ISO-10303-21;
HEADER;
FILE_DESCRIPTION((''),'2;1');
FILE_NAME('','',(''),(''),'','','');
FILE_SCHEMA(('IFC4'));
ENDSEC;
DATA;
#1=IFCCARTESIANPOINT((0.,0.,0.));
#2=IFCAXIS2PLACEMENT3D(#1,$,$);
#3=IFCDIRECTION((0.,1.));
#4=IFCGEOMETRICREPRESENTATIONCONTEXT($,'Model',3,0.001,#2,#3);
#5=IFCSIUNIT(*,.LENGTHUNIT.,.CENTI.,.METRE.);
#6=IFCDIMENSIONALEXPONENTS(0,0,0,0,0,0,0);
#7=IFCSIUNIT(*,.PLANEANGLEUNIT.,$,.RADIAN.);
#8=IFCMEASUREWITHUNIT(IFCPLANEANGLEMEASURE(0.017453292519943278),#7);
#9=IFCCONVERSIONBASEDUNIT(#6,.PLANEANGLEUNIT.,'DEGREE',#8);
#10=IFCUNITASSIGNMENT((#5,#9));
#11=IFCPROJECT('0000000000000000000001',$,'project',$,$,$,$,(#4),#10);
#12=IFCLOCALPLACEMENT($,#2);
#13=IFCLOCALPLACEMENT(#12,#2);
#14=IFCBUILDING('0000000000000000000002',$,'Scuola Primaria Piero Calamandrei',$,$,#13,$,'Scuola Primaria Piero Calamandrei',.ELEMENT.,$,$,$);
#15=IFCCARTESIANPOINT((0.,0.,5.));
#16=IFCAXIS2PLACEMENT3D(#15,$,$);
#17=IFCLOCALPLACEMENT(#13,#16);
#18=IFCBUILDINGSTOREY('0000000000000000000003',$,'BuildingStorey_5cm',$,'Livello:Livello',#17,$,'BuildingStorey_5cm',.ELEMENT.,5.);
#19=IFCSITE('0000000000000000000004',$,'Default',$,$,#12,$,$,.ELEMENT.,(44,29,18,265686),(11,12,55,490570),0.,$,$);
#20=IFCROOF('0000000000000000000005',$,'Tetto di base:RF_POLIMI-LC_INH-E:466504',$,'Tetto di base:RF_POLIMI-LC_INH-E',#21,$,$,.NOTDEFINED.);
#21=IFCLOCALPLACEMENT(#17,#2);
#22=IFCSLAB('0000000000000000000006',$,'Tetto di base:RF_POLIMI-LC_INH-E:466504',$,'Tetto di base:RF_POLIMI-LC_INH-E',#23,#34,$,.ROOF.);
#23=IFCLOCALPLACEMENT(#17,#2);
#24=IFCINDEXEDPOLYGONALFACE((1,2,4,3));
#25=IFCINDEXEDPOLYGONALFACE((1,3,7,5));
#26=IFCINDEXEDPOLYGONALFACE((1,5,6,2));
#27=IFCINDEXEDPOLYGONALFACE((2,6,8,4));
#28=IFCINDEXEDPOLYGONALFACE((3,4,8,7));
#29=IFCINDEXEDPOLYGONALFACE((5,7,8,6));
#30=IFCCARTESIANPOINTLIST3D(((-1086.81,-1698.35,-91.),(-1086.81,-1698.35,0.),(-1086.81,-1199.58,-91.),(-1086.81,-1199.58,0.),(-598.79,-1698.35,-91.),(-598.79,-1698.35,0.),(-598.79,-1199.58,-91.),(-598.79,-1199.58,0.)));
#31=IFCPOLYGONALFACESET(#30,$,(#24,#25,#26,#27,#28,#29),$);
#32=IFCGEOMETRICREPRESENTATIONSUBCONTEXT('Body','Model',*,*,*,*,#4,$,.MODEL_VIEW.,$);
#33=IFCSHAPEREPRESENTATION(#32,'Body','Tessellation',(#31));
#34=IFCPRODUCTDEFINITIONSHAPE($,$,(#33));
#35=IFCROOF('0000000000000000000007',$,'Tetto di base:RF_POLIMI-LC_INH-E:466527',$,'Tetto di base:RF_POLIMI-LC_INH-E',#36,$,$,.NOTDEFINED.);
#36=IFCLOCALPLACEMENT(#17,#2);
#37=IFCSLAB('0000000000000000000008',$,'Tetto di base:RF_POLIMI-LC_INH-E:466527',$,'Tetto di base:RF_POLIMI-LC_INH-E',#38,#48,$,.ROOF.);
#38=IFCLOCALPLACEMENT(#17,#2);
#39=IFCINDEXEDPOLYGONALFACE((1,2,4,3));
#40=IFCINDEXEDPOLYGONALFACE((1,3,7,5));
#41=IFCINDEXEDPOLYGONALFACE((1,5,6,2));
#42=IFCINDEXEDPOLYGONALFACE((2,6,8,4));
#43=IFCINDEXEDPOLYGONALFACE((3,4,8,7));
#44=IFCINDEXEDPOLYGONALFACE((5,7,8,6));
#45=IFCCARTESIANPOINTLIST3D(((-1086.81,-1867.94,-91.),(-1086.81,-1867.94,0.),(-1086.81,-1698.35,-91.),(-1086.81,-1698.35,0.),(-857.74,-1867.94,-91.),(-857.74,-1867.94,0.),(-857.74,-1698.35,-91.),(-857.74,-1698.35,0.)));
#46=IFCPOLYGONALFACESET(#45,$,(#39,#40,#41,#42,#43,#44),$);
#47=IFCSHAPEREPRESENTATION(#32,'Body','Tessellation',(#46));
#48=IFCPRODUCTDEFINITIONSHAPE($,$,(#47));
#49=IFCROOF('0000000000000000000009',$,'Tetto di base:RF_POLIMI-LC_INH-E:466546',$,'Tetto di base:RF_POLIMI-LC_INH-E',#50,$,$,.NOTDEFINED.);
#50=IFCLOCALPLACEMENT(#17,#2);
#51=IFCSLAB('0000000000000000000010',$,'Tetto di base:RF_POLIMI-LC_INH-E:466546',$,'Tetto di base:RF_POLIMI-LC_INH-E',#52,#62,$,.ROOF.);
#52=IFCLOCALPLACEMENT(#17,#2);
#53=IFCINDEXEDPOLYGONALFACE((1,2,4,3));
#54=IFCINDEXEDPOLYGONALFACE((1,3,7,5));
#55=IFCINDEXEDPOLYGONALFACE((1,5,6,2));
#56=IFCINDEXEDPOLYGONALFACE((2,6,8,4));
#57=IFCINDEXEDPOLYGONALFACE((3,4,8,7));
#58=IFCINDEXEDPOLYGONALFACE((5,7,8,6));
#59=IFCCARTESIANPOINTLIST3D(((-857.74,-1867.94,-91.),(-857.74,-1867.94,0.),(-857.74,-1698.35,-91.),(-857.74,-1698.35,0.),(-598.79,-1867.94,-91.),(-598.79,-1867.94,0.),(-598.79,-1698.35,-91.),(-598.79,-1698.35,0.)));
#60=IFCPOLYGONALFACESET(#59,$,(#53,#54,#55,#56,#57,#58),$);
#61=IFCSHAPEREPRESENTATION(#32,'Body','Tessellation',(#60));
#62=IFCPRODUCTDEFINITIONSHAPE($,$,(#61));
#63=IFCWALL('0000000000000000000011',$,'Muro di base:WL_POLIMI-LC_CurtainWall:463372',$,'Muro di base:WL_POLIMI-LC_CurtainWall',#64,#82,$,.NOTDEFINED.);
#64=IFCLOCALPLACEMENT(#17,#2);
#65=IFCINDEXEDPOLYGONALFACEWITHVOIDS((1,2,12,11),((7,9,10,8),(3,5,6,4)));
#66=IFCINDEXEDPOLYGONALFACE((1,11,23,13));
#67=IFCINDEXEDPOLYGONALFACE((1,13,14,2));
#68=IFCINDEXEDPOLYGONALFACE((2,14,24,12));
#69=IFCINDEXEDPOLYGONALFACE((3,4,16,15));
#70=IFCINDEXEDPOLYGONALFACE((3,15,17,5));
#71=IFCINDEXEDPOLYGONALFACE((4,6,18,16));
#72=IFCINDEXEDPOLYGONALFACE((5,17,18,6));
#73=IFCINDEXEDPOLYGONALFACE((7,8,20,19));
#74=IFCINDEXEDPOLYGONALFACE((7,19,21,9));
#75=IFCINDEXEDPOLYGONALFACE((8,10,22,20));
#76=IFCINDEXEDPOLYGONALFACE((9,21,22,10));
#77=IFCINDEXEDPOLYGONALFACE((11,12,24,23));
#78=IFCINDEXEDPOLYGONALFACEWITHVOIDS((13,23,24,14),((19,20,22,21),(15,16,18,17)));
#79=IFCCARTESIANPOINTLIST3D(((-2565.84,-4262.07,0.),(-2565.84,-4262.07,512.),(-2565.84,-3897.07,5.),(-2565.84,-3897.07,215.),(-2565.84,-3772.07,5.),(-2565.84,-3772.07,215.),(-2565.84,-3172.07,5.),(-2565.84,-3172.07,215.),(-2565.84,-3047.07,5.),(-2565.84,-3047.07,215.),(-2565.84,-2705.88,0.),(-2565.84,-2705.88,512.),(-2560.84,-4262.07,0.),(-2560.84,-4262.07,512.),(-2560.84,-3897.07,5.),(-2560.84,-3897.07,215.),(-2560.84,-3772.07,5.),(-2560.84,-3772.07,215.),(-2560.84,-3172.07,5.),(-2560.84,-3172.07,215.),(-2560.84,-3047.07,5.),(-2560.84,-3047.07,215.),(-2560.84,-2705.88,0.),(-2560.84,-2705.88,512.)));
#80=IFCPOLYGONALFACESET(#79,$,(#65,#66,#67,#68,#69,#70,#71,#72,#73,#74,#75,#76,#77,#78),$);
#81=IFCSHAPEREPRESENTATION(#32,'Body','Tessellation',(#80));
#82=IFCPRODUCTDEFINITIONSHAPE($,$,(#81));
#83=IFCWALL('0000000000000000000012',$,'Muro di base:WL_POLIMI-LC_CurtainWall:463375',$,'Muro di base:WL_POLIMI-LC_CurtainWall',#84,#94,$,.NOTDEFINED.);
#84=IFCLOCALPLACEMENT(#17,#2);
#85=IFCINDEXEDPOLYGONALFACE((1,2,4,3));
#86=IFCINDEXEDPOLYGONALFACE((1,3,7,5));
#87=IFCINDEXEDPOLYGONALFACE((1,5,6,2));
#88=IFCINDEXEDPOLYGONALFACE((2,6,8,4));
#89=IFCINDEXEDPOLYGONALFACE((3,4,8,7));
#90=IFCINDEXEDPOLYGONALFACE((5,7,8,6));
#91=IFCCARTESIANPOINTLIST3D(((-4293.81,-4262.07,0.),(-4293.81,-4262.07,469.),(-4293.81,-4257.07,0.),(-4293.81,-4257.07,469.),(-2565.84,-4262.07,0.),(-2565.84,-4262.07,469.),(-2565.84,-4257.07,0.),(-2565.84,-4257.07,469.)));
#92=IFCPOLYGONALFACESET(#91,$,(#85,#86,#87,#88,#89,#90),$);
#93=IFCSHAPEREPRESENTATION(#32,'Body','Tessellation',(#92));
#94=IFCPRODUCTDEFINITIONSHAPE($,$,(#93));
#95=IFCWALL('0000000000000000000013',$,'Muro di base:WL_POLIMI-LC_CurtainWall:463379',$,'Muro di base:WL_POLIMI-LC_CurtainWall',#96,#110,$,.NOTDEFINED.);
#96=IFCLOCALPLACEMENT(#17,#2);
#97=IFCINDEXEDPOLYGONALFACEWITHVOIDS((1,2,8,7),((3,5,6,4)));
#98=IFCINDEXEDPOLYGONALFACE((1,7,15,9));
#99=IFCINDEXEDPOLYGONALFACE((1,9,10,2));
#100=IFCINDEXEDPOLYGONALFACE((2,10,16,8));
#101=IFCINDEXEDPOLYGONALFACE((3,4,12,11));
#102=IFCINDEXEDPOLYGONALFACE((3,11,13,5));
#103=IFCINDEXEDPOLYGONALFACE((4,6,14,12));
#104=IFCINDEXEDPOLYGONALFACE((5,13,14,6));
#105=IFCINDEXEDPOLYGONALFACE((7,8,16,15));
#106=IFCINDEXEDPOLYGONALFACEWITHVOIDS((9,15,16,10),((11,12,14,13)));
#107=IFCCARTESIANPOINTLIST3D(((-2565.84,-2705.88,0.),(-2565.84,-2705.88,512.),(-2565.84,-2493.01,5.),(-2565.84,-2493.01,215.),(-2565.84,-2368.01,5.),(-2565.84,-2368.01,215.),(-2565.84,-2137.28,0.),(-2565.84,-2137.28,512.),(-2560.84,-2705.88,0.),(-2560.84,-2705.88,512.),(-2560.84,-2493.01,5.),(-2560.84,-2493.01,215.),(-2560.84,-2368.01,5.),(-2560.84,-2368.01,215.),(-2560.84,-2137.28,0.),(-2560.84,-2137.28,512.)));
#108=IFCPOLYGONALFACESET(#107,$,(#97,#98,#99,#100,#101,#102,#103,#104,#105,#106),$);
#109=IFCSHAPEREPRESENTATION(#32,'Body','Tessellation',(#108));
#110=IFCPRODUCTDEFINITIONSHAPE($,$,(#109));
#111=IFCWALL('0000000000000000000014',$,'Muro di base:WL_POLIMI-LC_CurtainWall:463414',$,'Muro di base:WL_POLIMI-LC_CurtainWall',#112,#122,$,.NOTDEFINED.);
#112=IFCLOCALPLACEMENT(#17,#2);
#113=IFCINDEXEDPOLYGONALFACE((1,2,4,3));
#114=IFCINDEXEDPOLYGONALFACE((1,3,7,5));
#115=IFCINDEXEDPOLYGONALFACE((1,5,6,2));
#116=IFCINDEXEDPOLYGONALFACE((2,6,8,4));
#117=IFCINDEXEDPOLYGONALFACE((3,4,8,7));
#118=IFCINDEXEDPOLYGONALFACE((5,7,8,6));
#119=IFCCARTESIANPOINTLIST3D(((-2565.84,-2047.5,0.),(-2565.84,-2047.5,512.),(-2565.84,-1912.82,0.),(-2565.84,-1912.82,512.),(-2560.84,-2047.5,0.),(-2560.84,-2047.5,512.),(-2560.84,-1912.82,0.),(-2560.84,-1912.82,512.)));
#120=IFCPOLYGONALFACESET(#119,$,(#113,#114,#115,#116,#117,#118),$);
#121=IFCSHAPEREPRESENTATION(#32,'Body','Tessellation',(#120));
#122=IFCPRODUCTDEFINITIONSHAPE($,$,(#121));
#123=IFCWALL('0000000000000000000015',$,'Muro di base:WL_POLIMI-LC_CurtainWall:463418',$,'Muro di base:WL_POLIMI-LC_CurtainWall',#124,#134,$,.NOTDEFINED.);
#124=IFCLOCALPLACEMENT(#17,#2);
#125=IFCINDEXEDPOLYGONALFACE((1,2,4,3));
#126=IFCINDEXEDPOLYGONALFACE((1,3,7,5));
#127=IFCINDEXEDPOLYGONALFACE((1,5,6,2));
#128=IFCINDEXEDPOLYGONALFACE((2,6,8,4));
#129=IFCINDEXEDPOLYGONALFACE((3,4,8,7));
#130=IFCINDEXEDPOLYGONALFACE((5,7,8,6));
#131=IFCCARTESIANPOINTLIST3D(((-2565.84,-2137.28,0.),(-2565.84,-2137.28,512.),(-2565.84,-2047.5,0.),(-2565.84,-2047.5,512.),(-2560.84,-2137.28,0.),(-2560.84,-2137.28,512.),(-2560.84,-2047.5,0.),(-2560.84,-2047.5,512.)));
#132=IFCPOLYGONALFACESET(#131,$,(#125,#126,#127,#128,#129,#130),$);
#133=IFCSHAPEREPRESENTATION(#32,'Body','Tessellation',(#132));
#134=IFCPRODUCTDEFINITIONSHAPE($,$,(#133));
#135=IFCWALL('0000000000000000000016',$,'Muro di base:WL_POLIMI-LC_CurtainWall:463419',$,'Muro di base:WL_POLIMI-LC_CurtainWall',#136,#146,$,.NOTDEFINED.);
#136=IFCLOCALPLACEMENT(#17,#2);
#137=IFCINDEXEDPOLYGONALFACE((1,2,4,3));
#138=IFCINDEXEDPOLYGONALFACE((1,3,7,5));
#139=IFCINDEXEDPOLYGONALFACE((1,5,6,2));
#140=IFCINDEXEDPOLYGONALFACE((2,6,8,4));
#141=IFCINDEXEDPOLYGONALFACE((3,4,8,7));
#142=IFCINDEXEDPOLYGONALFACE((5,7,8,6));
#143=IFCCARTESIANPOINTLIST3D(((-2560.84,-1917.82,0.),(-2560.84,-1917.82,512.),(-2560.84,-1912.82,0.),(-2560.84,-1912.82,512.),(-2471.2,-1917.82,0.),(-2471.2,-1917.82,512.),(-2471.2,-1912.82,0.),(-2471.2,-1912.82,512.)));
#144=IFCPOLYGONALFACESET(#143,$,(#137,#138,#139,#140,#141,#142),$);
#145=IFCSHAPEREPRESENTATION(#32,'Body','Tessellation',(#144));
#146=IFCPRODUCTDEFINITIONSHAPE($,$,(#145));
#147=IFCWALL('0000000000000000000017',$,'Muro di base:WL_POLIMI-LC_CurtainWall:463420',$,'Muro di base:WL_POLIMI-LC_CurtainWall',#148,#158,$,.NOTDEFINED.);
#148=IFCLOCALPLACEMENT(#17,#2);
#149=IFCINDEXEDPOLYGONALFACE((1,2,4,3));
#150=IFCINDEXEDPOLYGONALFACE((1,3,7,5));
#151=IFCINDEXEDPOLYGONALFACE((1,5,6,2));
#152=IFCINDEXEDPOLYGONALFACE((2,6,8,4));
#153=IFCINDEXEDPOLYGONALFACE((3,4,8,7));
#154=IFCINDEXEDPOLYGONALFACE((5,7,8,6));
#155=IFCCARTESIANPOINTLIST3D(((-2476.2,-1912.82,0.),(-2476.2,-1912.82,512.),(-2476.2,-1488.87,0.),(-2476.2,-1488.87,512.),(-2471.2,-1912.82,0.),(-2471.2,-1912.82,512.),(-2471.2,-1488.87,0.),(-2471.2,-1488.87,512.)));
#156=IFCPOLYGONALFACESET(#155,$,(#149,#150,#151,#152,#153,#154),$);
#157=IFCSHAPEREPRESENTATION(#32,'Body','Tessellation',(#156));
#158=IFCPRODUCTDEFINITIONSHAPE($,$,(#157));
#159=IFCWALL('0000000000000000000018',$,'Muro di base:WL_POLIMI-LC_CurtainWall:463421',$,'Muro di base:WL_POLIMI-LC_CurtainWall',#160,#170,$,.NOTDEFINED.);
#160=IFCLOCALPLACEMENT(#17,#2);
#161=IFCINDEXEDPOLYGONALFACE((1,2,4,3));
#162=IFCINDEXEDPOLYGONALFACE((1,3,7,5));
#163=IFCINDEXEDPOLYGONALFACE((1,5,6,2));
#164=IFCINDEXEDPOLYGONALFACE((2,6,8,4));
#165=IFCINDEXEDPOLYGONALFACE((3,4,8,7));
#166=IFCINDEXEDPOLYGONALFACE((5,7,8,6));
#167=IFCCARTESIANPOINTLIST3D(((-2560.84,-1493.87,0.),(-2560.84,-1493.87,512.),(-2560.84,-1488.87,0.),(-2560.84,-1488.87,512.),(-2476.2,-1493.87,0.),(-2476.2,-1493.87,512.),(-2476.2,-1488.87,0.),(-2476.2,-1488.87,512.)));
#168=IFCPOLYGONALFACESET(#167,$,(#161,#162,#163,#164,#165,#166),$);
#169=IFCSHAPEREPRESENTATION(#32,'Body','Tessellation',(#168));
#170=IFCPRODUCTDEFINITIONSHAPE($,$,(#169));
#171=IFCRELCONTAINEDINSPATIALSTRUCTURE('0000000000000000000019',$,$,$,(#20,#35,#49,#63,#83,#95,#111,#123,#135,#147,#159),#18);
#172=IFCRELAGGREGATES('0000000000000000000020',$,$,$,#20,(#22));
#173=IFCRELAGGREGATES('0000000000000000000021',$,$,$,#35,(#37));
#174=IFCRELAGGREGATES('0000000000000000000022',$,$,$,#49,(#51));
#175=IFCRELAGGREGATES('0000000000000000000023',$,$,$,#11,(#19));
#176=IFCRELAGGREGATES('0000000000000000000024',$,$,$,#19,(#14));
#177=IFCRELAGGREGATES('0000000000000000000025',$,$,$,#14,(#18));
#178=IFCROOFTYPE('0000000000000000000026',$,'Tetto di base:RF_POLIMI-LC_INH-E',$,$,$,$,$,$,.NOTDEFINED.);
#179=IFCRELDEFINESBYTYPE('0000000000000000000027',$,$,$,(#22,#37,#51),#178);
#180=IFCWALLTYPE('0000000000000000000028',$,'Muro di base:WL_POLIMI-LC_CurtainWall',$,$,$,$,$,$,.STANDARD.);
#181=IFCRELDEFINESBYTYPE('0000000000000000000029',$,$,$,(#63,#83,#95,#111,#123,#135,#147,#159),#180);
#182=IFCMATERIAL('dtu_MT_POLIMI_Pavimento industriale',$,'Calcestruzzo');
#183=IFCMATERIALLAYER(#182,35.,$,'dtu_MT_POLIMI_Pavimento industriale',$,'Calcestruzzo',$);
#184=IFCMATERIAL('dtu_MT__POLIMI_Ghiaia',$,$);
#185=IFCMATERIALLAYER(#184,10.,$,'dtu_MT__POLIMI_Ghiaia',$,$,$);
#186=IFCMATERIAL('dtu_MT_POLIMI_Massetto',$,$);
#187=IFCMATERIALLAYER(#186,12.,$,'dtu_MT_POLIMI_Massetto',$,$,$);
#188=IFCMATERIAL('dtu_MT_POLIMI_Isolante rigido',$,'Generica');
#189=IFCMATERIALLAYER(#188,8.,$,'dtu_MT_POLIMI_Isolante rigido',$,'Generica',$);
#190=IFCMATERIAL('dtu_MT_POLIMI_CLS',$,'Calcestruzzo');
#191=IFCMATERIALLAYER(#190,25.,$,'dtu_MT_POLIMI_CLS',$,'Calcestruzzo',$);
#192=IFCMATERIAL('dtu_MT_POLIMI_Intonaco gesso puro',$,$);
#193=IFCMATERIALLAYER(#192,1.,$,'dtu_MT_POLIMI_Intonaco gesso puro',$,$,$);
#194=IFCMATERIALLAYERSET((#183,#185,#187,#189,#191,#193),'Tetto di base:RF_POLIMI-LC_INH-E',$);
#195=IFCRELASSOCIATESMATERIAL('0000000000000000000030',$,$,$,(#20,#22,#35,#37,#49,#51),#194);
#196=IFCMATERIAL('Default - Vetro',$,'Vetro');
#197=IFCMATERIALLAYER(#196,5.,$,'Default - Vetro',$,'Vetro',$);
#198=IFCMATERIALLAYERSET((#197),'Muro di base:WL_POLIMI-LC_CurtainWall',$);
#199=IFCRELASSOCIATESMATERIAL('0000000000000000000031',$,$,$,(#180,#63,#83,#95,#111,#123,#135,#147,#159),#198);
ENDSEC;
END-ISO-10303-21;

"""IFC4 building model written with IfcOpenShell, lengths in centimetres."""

from ifc_helpers import new_model, entity, si_unit, converted_unit, direction, frame, frame_2d, origin, place, context, subcontext, project, spatial, polyline, rectangle, extrude, clip, bounded_halfspace, material, layer, layer_set, layer_usage, type_object, element, aggregate, save


model = new_model("IFC4")

# Units and contexts
model_context = context("Model", 3, precision=0.001, world=origin(), true_north=direction((0.0, 1.0)))
body_context = subcontext(model_context, "Body", "Model", "MODEL_VIEW")
ifc_project = project(units=[si_unit("LENGTHUNIT", "METRE", prefix="CENTI"), converted_unit("PLANEANGLEUNIT", "DEGREE", entity("IfcPlaneAngleMeasure", 0.017453292519943278), si_unit("PLANEANGLEUNIT", "RADIAN"), dimensions=[0, 0, 0, 0, 0, 0, 0])], contexts=[model_context])

# Site, building, storey
site_placement = place(None, origin())
site = spatial("IfcSite", under=ifc_project, at=site_placement, Name="Default", CompositionType="ELEMENT", RefLatitude=(44, 29, 18, 265686), RefLongitude=(11, 12, 55, 490570), RefElevation=0.0)
building_placement = place(site_placement, origin())
building = spatial("IfcBuilding", under=site, at=building_placement, Name="Scuola Primaria Piero Calamandrei", LongName="Scuola Primaria Piero Calamandrei", CompositionType="ELEMENT")
storey_placement = place(building_placement, frame((0.0, 0.0, 5.0)))
storey = spatial("IfcBuildingStorey", under=building, at=storey_placement, Name="BuildingStorey_5cm", ObjectType="Livello:Livello", LongName="BuildingStorey_5cm", CompositionType="ELEMENT", Elevation=5.0)

# Roofs, slabs
ifc_material_1 = material(Name="dtu_MT_POLIMI_Pavimento industriale", Category="Calcestruzzo")
ifc_layer_1 = layer(ifc_material_1, 35.0, Name="dtu_MT_POLIMI_Pavimento industriale", Category="Calcestruzzo")
ifc_material_2 = material(Name="dtu_MT__POLIMI_Ghiaia")
ifc_layer_2 = layer(ifc_material_2, 10.0, Name="dtu_MT__POLIMI_Ghiaia")
ifc_material_3 = material(Name="dtu_MT_POLIMI_Massetto")
ifc_layer_3 = layer(ifc_material_3, 12.0, Name="dtu_MT_POLIMI_Massetto")
ifc_material_4 = material(Name="dtu_MT_POLIMI_Isolante rigido", Category="Generica")
ifc_layer_4 = layer(ifc_material_4, 8.0, Name="dtu_MT_POLIMI_Isolante rigido", Category="Generica")
ifc_material_5 = material(Name="dtu_MT_POLIMI_CLS", Category="Calcestruzzo")
ifc_layer_5 = layer(ifc_material_5, 25.0, Name="dtu_MT_POLIMI_CLS", Category="Calcestruzzo")
ifc_material_6 = material(Name="dtu_MT_POLIMI_Intonaco gesso puro")
ifc_layer_6 = layer(ifc_material_6, 1.0, Name="dtu_MT_POLIMI_Intonaco gesso puro")
ifc_layer_set_1 = layer_set([ifc_layer_1, ifc_layer_2, ifc_layer_3, ifc_layer_4, ifc_layer_5, ifc_layer_6], Name="Tetto di base:RF_POLIMI-LC_INH-E")
roof_type = type_object("IfcRoofType", Name="Tetto di base:RF_POLIMI-LC_INH-E", PredefinedType="NOTDEFINED")
roof_1_placement = place(storey_placement, frame((-1086.81, -1698.35, -91.0)))
roof_1 = element("IfcRoof", 1, at=roof_1_placement, inside=storey, material=ifc_layer_set_1, Name="Tetto di base:RF_POLIMI-LC_INH-E:466504", ObjectType="Tetto di base:RF_POLIMI-LC_INH-E", PredefinedType="NOTDEFINED")
slab_1_placement = place(roof_1_placement, origin())
slab_1 = element("IfcSlab", 2, at=slab_1_placement, type_object=roof_type, material=ifc_layer_set_1, Name="Tetto di base:RF_POLIMI-LC_INH-E:466504", ObjectType="Tetto di base:RF_POLIMI-LC_INH-E", PredefinedType="ROOF", context=body_context, shape_type="SweptSolid", body=[
    extrude(rectangle(XDim=498.78, YDim=488.02, at=frame_2d((0.0, 0.0), x_axis=(0.0, -1.0))), frame((244.01, 249.39, 0.0)), (0.0, 0.0, 1.0), 91.0),
])
aggregate(roof_1, [slab_1])
roof_2_placement = place(storey_placement, frame((-1086.81, -1867.94, -91.0)))
roof_2 = element("IfcRoof", 3, at=roof_2_placement, inside=storey, material=ifc_layer_set_1, Name="Tetto di base:RF_POLIMI-LC_INH-E:466527", ObjectType="Tetto di base:RF_POLIMI-LC_INH-E", PredefinedType="NOTDEFINED")
slab_2_placement = place(roof_2_placement, origin())
slab_2 = element("IfcSlab", 4, at=slab_2_placement, type_object=roof_type, material=ifc_layer_set_1, Name="Tetto di base:RF_POLIMI-LC_INH-E:466527", ObjectType="Tetto di base:RF_POLIMI-LC_INH-E", PredefinedType="ROOF", context=body_context, shape_type="SweptSolid", body=[
    extrude(rectangle(XDim=169.58, YDim=229.07, at=frame_2d((0.0, 0.0), x_axis=(0.0, -1.0))), frame((114.54, 84.79, 0.0)), (0.0, 0.0, 1.0), 91.0),
])
aggregate(roof_2, [slab_2])
roof_3_placement = place(storey_placement, frame((-857.74, -1867.94, -91.0)))
roof_3 = element("IfcRoof", 5, at=roof_3_placement, inside=storey, material=ifc_layer_set_1, Name="Tetto di base:RF_POLIMI-LC_INH-E:466546", ObjectType="Tetto di base:RF_POLIMI-LC_INH-E", PredefinedType="NOTDEFINED")
slab_3_placement = place(roof_3_placement, origin())
slab_3 = element("IfcSlab", 6, at=slab_3_placement, type_object=roof_type, material=ifc_layer_set_1, Name="Tetto di base:RF_POLIMI-LC_INH-E:466546", ObjectType="Tetto di base:RF_POLIMI-LC_INH-E", PredefinedType="ROOF", context=body_context, shape_type="SweptSolid", body=[
    extrude(rectangle(XDim=169.58, YDim=258.95, at=frame_2d((0.0, 0.0), x_axis=(0.0, -1.0))), frame((129.48, 84.79, 0.0)), (0.0, 0.0, 1.0), 91.0),
])
aggregate(roof_3, [slab_3])

# Wall, openings
ifc_material_7 = material(Name="Default - Vetro", Category="Vetro")
ifc_layer_7 = layer(ifc_material_7, 5.0, Name="Default - Vetro", Category="Vetro")
ifc_layer_set_2 = layer_set([ifc_layer_7], Name="Muro di base:WL_POLIMI-LC_CurtainWall")
ifc_layer_usage_1 = layer_usage(ifc_layer_set_2, "AXIS2", "NEGATIVE", 2.5)
wall_type_1 = type_object("IfcWallType", Name="Muro di base:WL_POLIMI-LC_CurtainWall", PredefinedType="STANDARD", material=ifc_layer_set_2)
wall_1_placement = place(storey_placement, frame((-2563.34, -2705.88, 0.0), z_axis=(0.0, 0.0, 1.0), x_axis=(0.0, -1.0, 0.0)))
wall_1 = element("IfcWall", 7, at=wall_1_placement, inside=storey, type_object=wall_type_1, material=ifc_layer_usage_1, Name="Muro di base:WL_POLIMI-LC_CurtainWall:463372", ObjectType="Muro di base:WL_POLIMI-LC_CurtainWall", PredefinedType="NOTDEFINED", context=body_context, shape_type="SweptSolid", body=[
    extrude(rectangle(XDim=1556.19, YDim=5.0, at=frame_2d((778.09, 0.0), x_axis=(-1.0, 0.0))), origin(), (0.0, 0.0, 1.0), 512.0),
])
opening_1_placement = place(wall_1_placement, frame((1066.19, -2.5, 5.0)))
element("IfcOpeningElement", 8, at=opening_1_placement, cuts=wall_1, PredefinedType="OPENING", context=body_context, shape_type="SweptSolid", body=[
    extrude(rectangle(XDim=210.0, YDim=125.0, at=frame_2d((105.0, 62.5), x_axis=(-1.0, 0.0))), frame((0.0, 0.0, 0.0), z_axis=(0.0, 1.0, 0.0), x_axis=(0.0, 0.0, 1.0)), (0.0, 0.0, 1.0), 5.0),
])
opening_2_placement = place(wall_1_placement, frame((341.19, -2.5, 5.0)))
element("IfcOpeningElement", 9, at=opening_2_placement, cuts=wall_1, PredefinedType="OPENING", context=body_context, shape_type="SweptSolid", body=[
    extrude(rectangle(XDim=210.0, YDim=125.0, at=frame_2d((105.0, 62.5), x_axis=(-1.0, 0.0))), frame((0.0, 0.0, 0.0), z_axis=(0.0, 1.0, 0.0), x_axis=(0.0, 0.0, 1.0)), (0.0, 0.0, 1.0), 5.0),
])

# Wall
ifc_layer_usage_2 = layer_usage(ifc_layer_set_2, "AXIS2", "NEGATIVE", 2.5)
wall_2_placement = place(storey_placement, frame((-2565.84, -4259.57, 0.0), z_axis=(0.0, 0.0, 1.0), x_axis=(-1.0, 0.0, 0.0)))
element("IfcWall", 10, at=wall_2_placement, inside=storey, type_object=wall_type_1, material=ifc_layer_usage_2, Name="Muro di base:WL_POLIMI-LC_CurtainWall:463375", ObjectType="Muro di base:WL_POLIMI-LC_CurtainWall", PredefinedType="NOTDEFINED", context=body_context, shape_type="Clipping", body=[
    clip(extrude(rectangle(XDim=1727.97, YDim=5.0, at=frame_2d((863.99, 0.0), x_axis=(-1.0, 0.0))), origin(), (0.0, 0.0, 1.0), 469.0), bounded_halfspace(frame((84.64, -2.5, 469.0), z_axis=(0.0, 0.0, -1.0), x_axis=(-1.0, 0.0, 0.0)), True, frame((84.64, -2.5, 469.0)), polyline([(0.0, 0.0), (1643.34, 0.0), (1643.34, 5.0), (0.0, 5.0), (0.0, 0.0)]))),
])

# Wall, opening
ifc_layer_usage_3 = layer_usage(ifc_layer_set_2, "AXIS2", "NEGATIVE", 2.5)
wall_3_placement = place(storey_placement, frame((-2563.34, -2137.28, 0.0), z_axis=(0.0, 0.0, 1.0), x_axis=(0.0, -1.0, 0.0)))
wall_3 = element("IfcWall", 11, at=wall_3_placement, inside=storey, type_object=wall_type_1, material=ifc_layer_usage_3, Name="Muro di base:WL_POLIMI-LC_CurtainWall:463379", ObjectType="Muro di base:WL_POLIMI-LC_CurtainWall", PredefinedType="NOTDEFINED", context=body_context, shape_type="SweptSolid", body=[
    extrude(rectangle(XDim=568.61, YDim=5.0, at=frame_2d((284.3, 0.0), x_axis=(-1.0, 0.0))), origin(), (0.0, 0.0, 1.0), 512.0),
])
opening_3_placement = place(wall_3_placement, frame((230.73, -2.5, 5.0)))
element("IfcOpeningElement", 12, at=opening_3_placement, cuts=wall_3, PredefinedType="OPENING", context=body_context, shape_type="SweptSolid", body=[
    extrude(rectangle(XDim=210.0, YDim=125.0, at=frame_2d((105.0, 62.5), x_axis=(-1.0, 0.0))), frame((0.0, 0.0, 0.0), z_axis=(0.0, 1.0, 0.0), x_axis=(0.0, 0.0, 1.0)), (0.0, 0.0, 1.0), 5.0),
])

# Walls
ifc_layer_usage_4 = layer_usage(ifc_layer_set_2, "AXIS2", "NEGATIVE", 2.5)
wall_4_placement = place(storey_placement, frame((-2563.34, -1912.82, 0.0), z_axis=(0.0, 0.0, 1.0), x_axis=(0.0, -1.0, 0.0)))
element("IfcWall", 13, at=wall_4_placement, inside=storey, type_object=wall_type_1, material=ifc_layer_usage_4, Name="Muro di base:WL_POLIMI-LC_CurtainWall:463414", ObjectType="Muro di base:WL_POLIMI-LC_CurtainWall", PredefinedType="NOTDEFINED", context=body_context, shape_type="SweptSolid", body=[
    extrude(rectangle(XDim=134.68, YDim=5.0, at=frame_2d((67.34, 0.0), x_axis=(-1.0, 0.0))), origin(), (0.0, 0.0, 1.0), 512.0),
])
ifc_layer_usage_5 = layer_usage(ifc_layer_set_2, "AXIS2", "NEGATIVE", 2.5)
wall_5_placement = place(storey_placement, frame((-2563.34, -2047.5, 0.0), z_axis=(0.0, 0.0, 1.0), x_axis=(0.0, -1.0, 0.0)))
element("IfcWall", 14, at=wall_5_placement, inside=storey, type_object=wall_type_1, material=ifc_layer_usage_5, Name="Muro di base:WL_POLIMI-LC_CurtainWall:463418", ObjectType="Muro di base:WL_POLIMI-LC_CurtainWall", PredefinedType="NOTDEFINED", context=body_context, shape_type="SweptSolid", body=[
    extrude(rectangle(XDim=89.78, YDim=5.0, at=frame_2d((44.89, 0.0), x_axis=(-1.0, 0.0))), origin(), (0.0, 0.0, 1.0), 512.0),
])
ifc_layer_usage_6 = layer_usage(ifc_layer_set_2, "AXIS2", "NEGATIVE", 2.5)
wall_6_placement = place(storey_placement, frame((-2471.2, -1915.32, 0.0), z_axis=(0.0, 0.0, 1.0), x_axis=(-1.0, 0.0, 0.0)))
element("IfcWall", 15, at=wall_6_placement, inside=storey, type_object=wall_type_1, material=ifc_layer_usage_6, Name="Muro di base:WL_POLIMI-LC_CurtainWall:463419", ObjectType="Muro di base:WL_POLIMI-LC_CurtainWall", PredefinedType="NOTDEFINED", context=body_context, shape_type="SweptSolid", body=[
    extrude(rectangle(XDim=89.64, YDim=5.0, at=frame_2d((44.82, 0.0), x_axis=(-1.0, 0.0))), origin(), (0.0, 0.0, 1.0), 512.0),
])
ifc_layer_usage_7 = layer_usage(ifc_layer_set_2, "AXIS2", "NEGATIVE", 2.5)
wall_7_placement = place(storey_placement, frame((-2473.7, -1488.87, 0.0), z_axis=(0.0, 0.0, 1.0), x_axis=(0.0, -1.0, 0.0)))
element("IfcWall", 16, at=wall_7_placement, inside=storey, type_object=wall_type_1, material=ifc_layer_usage_7, Name="Muro di base:WL_POLIMI-LC_CurtainWall:463420", ObjectType="Muro di base:WL_POLIMI-LC_CurtainWall", PredefinedType="NOTDEFINED", context=body_context, shape_type="SweptSolid", body=[
    extrude(rectangle(XDim=423.95, YDim=5.0, at=frame_2d((211.97, 0.0), x_axis=(-1.0, 0.0))), origin(), (0.0, 0.0, 1.0), 512.0),
])
ifc_layer_usage_8 = layer_usage(ifc_layer_set_2, "AXIS2", "NEGATIVE", 2.5)
wall_8_placement = place(storey_placement, frame((-2560.84, -1491.37, 0.0)))
element("IfcWall", 17, at=wall_8_placement, inside=storey, type_object=wall_type_1, material=ifc_layer_usage_8, Name="Muro di base:WL_POLIMI-LC_CurtainWall:463421", ObjectType="Muro di base:WL_POLIMI-LC_CurtainWall", PredefinedType="NOTDEFINED", context=body_context, shape_type="SweptSolid", body=[
    extrude(rectangle(XDim=84.64, YDim=5.0, at=frame_2d((42.32, 0.0), x_axis=(-1.0, 0.0))), origin(), (0.0, 0.0, 1.0), 512.0),
])

save(model, "model.ifc")
